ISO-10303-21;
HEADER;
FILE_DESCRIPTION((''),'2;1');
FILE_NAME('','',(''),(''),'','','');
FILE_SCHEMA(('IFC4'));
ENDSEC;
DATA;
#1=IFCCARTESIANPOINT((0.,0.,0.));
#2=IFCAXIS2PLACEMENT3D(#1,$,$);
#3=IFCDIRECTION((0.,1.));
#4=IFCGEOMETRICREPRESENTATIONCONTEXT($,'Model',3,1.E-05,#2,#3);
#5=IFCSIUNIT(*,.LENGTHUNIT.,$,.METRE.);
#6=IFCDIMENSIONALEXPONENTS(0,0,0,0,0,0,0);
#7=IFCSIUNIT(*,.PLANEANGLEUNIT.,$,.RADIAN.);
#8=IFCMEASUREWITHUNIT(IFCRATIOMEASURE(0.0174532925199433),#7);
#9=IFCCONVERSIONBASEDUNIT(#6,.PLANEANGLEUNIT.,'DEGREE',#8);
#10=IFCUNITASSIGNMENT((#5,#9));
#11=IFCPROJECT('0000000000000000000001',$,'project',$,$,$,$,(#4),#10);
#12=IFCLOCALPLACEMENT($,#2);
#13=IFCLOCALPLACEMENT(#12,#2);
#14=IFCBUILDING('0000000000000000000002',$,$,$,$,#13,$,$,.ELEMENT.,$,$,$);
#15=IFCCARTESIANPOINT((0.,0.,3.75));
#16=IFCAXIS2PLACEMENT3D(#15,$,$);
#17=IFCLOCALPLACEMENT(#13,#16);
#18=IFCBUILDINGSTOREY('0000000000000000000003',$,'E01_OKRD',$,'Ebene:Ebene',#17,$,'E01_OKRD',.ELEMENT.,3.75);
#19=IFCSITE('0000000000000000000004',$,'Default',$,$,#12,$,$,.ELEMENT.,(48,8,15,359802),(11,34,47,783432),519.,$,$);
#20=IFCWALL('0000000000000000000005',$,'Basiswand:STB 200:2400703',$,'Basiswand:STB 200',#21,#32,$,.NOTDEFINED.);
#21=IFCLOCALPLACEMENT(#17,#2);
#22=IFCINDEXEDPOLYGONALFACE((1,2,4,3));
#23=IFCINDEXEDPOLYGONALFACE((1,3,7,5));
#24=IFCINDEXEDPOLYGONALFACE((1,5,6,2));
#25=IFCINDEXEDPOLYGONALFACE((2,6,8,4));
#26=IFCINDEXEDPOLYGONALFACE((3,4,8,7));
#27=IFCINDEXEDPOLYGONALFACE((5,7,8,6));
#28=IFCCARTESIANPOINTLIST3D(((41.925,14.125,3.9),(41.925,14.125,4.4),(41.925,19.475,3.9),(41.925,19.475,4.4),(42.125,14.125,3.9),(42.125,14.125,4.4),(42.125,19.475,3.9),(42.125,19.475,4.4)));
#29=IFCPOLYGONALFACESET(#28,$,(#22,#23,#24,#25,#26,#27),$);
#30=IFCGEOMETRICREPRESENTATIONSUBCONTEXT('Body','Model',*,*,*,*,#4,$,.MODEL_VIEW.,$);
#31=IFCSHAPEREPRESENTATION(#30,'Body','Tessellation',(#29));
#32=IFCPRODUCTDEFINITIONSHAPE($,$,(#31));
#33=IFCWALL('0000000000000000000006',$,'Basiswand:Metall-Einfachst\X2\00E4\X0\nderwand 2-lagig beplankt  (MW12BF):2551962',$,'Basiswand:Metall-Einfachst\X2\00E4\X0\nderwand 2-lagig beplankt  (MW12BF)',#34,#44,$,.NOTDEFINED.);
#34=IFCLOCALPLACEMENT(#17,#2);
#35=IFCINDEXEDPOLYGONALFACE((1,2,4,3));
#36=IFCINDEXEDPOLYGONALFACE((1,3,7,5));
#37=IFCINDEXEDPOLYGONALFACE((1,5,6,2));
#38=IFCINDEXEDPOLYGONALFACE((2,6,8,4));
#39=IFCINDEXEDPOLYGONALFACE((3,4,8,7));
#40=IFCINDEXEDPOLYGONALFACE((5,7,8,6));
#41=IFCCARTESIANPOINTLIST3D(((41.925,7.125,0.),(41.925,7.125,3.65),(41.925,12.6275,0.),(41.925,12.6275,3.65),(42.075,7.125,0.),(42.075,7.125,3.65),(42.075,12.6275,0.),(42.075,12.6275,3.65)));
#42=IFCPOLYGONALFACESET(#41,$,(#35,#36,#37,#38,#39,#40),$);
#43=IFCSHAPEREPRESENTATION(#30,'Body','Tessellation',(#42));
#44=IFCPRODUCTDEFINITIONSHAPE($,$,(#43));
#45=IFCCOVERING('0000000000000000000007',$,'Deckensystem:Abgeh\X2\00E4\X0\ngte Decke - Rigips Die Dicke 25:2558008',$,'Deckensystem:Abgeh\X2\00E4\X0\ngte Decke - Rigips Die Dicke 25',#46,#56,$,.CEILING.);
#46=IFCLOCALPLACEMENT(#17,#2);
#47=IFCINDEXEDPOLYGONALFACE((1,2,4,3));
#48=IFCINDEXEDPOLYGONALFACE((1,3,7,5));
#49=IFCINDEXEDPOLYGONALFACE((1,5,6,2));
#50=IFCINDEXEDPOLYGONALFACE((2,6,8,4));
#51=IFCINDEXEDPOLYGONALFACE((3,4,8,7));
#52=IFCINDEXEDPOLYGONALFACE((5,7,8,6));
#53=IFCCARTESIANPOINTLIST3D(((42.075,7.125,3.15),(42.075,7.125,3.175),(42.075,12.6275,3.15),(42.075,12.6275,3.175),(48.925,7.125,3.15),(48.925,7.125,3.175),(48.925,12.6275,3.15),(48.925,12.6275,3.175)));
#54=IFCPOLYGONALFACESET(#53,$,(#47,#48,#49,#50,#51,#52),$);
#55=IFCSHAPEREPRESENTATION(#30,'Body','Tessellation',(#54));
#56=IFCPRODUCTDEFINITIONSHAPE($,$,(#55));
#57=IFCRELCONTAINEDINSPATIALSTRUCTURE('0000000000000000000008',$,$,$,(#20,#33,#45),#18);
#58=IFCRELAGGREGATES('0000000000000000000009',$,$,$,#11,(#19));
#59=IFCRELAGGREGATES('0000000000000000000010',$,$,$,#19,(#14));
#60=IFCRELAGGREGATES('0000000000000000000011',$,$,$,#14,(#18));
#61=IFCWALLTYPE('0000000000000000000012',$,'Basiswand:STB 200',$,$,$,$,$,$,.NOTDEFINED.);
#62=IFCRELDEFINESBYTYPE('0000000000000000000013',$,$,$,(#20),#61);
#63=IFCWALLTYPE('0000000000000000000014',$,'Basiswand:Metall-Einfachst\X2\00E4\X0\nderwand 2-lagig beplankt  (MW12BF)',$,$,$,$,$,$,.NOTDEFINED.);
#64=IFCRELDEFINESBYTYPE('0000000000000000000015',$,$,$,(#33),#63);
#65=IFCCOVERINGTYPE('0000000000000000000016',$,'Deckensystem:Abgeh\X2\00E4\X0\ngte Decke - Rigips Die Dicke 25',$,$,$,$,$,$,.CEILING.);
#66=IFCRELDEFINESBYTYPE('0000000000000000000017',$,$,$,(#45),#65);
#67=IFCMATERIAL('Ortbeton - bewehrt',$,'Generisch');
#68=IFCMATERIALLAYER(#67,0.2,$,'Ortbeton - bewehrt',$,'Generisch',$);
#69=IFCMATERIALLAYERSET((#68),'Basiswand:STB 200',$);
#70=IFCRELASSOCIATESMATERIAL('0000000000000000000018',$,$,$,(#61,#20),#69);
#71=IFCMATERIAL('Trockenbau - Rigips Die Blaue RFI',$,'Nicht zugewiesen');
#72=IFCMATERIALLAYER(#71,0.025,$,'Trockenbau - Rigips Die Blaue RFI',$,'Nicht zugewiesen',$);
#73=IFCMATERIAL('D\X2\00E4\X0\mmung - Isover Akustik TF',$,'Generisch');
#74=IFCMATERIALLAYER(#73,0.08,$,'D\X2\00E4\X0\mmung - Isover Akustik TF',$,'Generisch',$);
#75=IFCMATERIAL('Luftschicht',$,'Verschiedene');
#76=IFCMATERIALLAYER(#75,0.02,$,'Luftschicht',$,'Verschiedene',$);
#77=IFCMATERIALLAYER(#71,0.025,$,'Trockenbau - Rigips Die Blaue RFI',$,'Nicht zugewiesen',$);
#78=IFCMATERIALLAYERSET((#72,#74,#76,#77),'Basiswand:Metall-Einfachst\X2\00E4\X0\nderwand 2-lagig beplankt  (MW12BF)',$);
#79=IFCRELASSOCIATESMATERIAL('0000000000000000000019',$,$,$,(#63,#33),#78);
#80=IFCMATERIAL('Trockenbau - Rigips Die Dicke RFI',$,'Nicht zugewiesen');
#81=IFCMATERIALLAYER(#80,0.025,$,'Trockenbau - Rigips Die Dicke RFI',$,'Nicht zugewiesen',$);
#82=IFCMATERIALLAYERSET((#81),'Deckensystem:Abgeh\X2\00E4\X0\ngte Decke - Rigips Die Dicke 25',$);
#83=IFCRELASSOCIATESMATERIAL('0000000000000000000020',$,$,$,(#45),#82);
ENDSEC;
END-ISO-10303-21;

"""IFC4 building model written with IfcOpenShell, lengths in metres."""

from ifc_helpers import new_model, entity, si_unit, converted_unit, direction, frame, frame_2d, origin, place, context, subcontext, project, spatial, rectangle, extrude, material, layer, layer_set, layer_usage, type_object, element, save


model = new_model("IFC4")

# Units and contexts
model_context = context("Model", 3, precision=1e-05, world=origin(), true_north=direction((0.0, 1.0)))
body_context = subcontext(model_context, "Body", "Model", "MODEL_VIEW")
ifc_project = project(units=[si_unit("LENGTHUNIT", "METRE"), converted_unit("PLANEANGLEUNIT", "DEGREE", entity("IfcRatioMeasure", 0.0174532925199433), si_unit("PLANEANGLEUNIT", "RADIAN"), dimensions=[0, 0, 0, 0, 0, 0, 0])], contexts=[model_context])

# Site, building, storey
site_placement = place(None, frame((0.0, 0.0, 0.0)))
site = spatial("IfcSite", under=ifc_project, at=site_placement, Name="Default", CompositionType="ELEMENT", RefLatitude=(48, 8, 15, 359802), RefLongitude=(11, 34, 47, 783432), RefElevation=519.0)
building_placement = place(site_placement, origin())
building = spatial("IfcBuilding", under=site, at=building_placement, CompositionType="ELEMENT")
storey_placement = place(building_placement, frame((0.0, 0.0, 3.75)))
storey = spatial("IfcBuildingStorey", under=building, at=storey_placement, Name="E01_OKRD", ObjectType="Ebene:Ebene", LongName="E01_OKRD", CompositionType="ELEMENT", Elevation=3.75)

# Shared definitions
ifc_material_1 = material(Name="Ortbeton - bewehrt", Category="Generisch")

# Walls
ifc_layer_1 = layer(ifc_material_1, 0.2, Name="Ortbeton - bewehrt", Category="Generisch")
ifc_layer_set_1 = layer_set([ifc_layer_1], Name="Basiswand:STB 200")
wall_type_1 = type_object("IfcWallType", Name="Basiswand:STB 200", PredefinedType="NOTDEFINED", material=ifc_layer_set_1)
ifc_layer_usage_1 = layer_usage(ifc_layer_set_1, "AXIS2", "NEGATIVE", 0.1)
wall_1_placement = place(storey_placement, frame((42.025, 14.125, 3.9), z_axis=(0.0, 0.0, 1.0), x_axis=(0.0, 1.0, 0.0)))
element("IfcWall", 1, at=wall_1_placement, inside=storey, type_object=wall_type_1, material=ifc_layer_usage_1, Name="Basiswand:STB 200:2400703", ObjectType="Basiswand:STB 200", PredefinedType="NOTDEFINED", context=body_context, shape_type="SweptSolid", body=[
    extrude(rectangle(XDim=5.35, YDim=0.2, at=frame_2d((2.675, 0.0), x_axis=(-1.0, 0.0))), origin(), (0.0, 0.0, 1.0), 0.5),
])
ifc_material_2 = material(Name="Trockenbau - Rigips Die Blaue RFI", Category="Nicht zugewiesen")
ifc_layer_2 = layer(ifc_material_2, 0.025, Name="Trockenbau - Rigips Die Blaue RFI", Category="Nicht zugewiesen")
ifc_material_3 = material(Name="Dämmung - Isover Akustik TF", Category="Generisch")
ifc_layer_3 = layer(ifc_material_3, 0.08, Name="Dämmung - Isover Akustik TF", Category="Generisch")
ifc_material_4 = material(Name="Luftschicht", Category="Verschiedene")
ifc_layer_4 = layer(ifc_material_4, 0.02, Name="Luftschicht", Category="Verschiedene")
ifc_layer_5 = layer(ifc_material_2, 0.025, Name="Trockenbau - Rigips Die Blaue RFI", Category="Nicht zugewiesen")
ifc_layer_set_2 = layer_set([ifc_layer_2, ifc_layer_3, ifc_layer_4, ifc_layer_5], Name="Basiswand:Metall-Einfachständerwand 2-lagig beplankt  (MW12BF)")
ifc_layer_usage_2 = layer_usage(ifc_layer_set_2, "AXIS2", "NEGATIVE", 0.075)
wall_type_2 = type_object("IfcWallType", Name="Basiswand:Metall-Einfachständerwand 2-lagig beplankt  (MW12BF)", PredefinedType="NOTDEFINED", material=ifc_layer_set_2)
wall_2_placement = place(storey_placement, frame((42.0, 7.125, 0.0), z_axis=(0.0, 0.0, 1.0), x_axis=(0.0, 1.0, 0.0)))
element("IfcWall", 2, at=wall_2_placement, inside=storey, type_object=wall_type_2, material=ifc_layer_usage_2, Name="Basiswand:Metall-Einfachständerwand 2-lagig beplankt  (MW12BF):2551962", ObjectType="Basiswand:Metall-Einfachständerwand 2-lagig beplankt  (MW12BF)", PredefinedType="NOTDEFINED", context=body_context, shape_type="SweptSolid", body=[
    extrude(rectangle(XDim=5.5025, YDim=0.15, at=frame_2d((2.7513, 0.0), x_axis=(-1.0, 0.0))), origin(), (0.0, 0.0, 1.0), 3.65),
])

# Covering
ifc_material_5 = material(Name="Trockenbau - Rigips Die Dicke RFI", Category="Nicht zugewiesen")
ifc_layer_6 = layer(ifc_material_5, 0.025, Name="Trockenbau - Rigips Die Dicke RFI", Category="Nicht zugewiesen")
ifc_layer_set_3 = layer_set([ifc_layer_6], Name="Deckensystem:Abgehängte Decke - Rigips Die Dicke 25")
ifc_layer_usage_3 = layer_usage(ifc_layer_set_3, "AXIS3", "POSITIVE", 0.0)
covering_type = type_object("IfcCoveringType", Name="Deckensystem:Abgehängte Decke - Rigips Die Dicke 25", PredefinedType="CEILING")
covering_placement = place(storey_placement, frame((42.075, 7.125, 3.15)))
element("IfcCovering", 3, at=covering_placement, inside=storey, type_object=covering_type, material=ifc_layer_usage_3, Name="Deckensystem:Abgehängte Decke - Rigips Die Dicke 25:2558008", ObjectType="Deckensystem:Abgehängte Decke - Rigips Die Dicke 25", PredefinedType="CEILING", context=body_context, shape_type="SweptSolid", body=[
    extrude(rectangle(XDim=5.5025, YDim=6.85, at=frame_2d((0.0, 0.0), x_axis=(1.0, 0.0))), frame((3.425, 2.7512, 0.0), z_axis=(0.0, 0.0, 1.0), x_axis=(0.0, -1.0, 0.0)), (0.0, 0.0, 1.0), 0.025),
])

save(model, "model.ifc")
